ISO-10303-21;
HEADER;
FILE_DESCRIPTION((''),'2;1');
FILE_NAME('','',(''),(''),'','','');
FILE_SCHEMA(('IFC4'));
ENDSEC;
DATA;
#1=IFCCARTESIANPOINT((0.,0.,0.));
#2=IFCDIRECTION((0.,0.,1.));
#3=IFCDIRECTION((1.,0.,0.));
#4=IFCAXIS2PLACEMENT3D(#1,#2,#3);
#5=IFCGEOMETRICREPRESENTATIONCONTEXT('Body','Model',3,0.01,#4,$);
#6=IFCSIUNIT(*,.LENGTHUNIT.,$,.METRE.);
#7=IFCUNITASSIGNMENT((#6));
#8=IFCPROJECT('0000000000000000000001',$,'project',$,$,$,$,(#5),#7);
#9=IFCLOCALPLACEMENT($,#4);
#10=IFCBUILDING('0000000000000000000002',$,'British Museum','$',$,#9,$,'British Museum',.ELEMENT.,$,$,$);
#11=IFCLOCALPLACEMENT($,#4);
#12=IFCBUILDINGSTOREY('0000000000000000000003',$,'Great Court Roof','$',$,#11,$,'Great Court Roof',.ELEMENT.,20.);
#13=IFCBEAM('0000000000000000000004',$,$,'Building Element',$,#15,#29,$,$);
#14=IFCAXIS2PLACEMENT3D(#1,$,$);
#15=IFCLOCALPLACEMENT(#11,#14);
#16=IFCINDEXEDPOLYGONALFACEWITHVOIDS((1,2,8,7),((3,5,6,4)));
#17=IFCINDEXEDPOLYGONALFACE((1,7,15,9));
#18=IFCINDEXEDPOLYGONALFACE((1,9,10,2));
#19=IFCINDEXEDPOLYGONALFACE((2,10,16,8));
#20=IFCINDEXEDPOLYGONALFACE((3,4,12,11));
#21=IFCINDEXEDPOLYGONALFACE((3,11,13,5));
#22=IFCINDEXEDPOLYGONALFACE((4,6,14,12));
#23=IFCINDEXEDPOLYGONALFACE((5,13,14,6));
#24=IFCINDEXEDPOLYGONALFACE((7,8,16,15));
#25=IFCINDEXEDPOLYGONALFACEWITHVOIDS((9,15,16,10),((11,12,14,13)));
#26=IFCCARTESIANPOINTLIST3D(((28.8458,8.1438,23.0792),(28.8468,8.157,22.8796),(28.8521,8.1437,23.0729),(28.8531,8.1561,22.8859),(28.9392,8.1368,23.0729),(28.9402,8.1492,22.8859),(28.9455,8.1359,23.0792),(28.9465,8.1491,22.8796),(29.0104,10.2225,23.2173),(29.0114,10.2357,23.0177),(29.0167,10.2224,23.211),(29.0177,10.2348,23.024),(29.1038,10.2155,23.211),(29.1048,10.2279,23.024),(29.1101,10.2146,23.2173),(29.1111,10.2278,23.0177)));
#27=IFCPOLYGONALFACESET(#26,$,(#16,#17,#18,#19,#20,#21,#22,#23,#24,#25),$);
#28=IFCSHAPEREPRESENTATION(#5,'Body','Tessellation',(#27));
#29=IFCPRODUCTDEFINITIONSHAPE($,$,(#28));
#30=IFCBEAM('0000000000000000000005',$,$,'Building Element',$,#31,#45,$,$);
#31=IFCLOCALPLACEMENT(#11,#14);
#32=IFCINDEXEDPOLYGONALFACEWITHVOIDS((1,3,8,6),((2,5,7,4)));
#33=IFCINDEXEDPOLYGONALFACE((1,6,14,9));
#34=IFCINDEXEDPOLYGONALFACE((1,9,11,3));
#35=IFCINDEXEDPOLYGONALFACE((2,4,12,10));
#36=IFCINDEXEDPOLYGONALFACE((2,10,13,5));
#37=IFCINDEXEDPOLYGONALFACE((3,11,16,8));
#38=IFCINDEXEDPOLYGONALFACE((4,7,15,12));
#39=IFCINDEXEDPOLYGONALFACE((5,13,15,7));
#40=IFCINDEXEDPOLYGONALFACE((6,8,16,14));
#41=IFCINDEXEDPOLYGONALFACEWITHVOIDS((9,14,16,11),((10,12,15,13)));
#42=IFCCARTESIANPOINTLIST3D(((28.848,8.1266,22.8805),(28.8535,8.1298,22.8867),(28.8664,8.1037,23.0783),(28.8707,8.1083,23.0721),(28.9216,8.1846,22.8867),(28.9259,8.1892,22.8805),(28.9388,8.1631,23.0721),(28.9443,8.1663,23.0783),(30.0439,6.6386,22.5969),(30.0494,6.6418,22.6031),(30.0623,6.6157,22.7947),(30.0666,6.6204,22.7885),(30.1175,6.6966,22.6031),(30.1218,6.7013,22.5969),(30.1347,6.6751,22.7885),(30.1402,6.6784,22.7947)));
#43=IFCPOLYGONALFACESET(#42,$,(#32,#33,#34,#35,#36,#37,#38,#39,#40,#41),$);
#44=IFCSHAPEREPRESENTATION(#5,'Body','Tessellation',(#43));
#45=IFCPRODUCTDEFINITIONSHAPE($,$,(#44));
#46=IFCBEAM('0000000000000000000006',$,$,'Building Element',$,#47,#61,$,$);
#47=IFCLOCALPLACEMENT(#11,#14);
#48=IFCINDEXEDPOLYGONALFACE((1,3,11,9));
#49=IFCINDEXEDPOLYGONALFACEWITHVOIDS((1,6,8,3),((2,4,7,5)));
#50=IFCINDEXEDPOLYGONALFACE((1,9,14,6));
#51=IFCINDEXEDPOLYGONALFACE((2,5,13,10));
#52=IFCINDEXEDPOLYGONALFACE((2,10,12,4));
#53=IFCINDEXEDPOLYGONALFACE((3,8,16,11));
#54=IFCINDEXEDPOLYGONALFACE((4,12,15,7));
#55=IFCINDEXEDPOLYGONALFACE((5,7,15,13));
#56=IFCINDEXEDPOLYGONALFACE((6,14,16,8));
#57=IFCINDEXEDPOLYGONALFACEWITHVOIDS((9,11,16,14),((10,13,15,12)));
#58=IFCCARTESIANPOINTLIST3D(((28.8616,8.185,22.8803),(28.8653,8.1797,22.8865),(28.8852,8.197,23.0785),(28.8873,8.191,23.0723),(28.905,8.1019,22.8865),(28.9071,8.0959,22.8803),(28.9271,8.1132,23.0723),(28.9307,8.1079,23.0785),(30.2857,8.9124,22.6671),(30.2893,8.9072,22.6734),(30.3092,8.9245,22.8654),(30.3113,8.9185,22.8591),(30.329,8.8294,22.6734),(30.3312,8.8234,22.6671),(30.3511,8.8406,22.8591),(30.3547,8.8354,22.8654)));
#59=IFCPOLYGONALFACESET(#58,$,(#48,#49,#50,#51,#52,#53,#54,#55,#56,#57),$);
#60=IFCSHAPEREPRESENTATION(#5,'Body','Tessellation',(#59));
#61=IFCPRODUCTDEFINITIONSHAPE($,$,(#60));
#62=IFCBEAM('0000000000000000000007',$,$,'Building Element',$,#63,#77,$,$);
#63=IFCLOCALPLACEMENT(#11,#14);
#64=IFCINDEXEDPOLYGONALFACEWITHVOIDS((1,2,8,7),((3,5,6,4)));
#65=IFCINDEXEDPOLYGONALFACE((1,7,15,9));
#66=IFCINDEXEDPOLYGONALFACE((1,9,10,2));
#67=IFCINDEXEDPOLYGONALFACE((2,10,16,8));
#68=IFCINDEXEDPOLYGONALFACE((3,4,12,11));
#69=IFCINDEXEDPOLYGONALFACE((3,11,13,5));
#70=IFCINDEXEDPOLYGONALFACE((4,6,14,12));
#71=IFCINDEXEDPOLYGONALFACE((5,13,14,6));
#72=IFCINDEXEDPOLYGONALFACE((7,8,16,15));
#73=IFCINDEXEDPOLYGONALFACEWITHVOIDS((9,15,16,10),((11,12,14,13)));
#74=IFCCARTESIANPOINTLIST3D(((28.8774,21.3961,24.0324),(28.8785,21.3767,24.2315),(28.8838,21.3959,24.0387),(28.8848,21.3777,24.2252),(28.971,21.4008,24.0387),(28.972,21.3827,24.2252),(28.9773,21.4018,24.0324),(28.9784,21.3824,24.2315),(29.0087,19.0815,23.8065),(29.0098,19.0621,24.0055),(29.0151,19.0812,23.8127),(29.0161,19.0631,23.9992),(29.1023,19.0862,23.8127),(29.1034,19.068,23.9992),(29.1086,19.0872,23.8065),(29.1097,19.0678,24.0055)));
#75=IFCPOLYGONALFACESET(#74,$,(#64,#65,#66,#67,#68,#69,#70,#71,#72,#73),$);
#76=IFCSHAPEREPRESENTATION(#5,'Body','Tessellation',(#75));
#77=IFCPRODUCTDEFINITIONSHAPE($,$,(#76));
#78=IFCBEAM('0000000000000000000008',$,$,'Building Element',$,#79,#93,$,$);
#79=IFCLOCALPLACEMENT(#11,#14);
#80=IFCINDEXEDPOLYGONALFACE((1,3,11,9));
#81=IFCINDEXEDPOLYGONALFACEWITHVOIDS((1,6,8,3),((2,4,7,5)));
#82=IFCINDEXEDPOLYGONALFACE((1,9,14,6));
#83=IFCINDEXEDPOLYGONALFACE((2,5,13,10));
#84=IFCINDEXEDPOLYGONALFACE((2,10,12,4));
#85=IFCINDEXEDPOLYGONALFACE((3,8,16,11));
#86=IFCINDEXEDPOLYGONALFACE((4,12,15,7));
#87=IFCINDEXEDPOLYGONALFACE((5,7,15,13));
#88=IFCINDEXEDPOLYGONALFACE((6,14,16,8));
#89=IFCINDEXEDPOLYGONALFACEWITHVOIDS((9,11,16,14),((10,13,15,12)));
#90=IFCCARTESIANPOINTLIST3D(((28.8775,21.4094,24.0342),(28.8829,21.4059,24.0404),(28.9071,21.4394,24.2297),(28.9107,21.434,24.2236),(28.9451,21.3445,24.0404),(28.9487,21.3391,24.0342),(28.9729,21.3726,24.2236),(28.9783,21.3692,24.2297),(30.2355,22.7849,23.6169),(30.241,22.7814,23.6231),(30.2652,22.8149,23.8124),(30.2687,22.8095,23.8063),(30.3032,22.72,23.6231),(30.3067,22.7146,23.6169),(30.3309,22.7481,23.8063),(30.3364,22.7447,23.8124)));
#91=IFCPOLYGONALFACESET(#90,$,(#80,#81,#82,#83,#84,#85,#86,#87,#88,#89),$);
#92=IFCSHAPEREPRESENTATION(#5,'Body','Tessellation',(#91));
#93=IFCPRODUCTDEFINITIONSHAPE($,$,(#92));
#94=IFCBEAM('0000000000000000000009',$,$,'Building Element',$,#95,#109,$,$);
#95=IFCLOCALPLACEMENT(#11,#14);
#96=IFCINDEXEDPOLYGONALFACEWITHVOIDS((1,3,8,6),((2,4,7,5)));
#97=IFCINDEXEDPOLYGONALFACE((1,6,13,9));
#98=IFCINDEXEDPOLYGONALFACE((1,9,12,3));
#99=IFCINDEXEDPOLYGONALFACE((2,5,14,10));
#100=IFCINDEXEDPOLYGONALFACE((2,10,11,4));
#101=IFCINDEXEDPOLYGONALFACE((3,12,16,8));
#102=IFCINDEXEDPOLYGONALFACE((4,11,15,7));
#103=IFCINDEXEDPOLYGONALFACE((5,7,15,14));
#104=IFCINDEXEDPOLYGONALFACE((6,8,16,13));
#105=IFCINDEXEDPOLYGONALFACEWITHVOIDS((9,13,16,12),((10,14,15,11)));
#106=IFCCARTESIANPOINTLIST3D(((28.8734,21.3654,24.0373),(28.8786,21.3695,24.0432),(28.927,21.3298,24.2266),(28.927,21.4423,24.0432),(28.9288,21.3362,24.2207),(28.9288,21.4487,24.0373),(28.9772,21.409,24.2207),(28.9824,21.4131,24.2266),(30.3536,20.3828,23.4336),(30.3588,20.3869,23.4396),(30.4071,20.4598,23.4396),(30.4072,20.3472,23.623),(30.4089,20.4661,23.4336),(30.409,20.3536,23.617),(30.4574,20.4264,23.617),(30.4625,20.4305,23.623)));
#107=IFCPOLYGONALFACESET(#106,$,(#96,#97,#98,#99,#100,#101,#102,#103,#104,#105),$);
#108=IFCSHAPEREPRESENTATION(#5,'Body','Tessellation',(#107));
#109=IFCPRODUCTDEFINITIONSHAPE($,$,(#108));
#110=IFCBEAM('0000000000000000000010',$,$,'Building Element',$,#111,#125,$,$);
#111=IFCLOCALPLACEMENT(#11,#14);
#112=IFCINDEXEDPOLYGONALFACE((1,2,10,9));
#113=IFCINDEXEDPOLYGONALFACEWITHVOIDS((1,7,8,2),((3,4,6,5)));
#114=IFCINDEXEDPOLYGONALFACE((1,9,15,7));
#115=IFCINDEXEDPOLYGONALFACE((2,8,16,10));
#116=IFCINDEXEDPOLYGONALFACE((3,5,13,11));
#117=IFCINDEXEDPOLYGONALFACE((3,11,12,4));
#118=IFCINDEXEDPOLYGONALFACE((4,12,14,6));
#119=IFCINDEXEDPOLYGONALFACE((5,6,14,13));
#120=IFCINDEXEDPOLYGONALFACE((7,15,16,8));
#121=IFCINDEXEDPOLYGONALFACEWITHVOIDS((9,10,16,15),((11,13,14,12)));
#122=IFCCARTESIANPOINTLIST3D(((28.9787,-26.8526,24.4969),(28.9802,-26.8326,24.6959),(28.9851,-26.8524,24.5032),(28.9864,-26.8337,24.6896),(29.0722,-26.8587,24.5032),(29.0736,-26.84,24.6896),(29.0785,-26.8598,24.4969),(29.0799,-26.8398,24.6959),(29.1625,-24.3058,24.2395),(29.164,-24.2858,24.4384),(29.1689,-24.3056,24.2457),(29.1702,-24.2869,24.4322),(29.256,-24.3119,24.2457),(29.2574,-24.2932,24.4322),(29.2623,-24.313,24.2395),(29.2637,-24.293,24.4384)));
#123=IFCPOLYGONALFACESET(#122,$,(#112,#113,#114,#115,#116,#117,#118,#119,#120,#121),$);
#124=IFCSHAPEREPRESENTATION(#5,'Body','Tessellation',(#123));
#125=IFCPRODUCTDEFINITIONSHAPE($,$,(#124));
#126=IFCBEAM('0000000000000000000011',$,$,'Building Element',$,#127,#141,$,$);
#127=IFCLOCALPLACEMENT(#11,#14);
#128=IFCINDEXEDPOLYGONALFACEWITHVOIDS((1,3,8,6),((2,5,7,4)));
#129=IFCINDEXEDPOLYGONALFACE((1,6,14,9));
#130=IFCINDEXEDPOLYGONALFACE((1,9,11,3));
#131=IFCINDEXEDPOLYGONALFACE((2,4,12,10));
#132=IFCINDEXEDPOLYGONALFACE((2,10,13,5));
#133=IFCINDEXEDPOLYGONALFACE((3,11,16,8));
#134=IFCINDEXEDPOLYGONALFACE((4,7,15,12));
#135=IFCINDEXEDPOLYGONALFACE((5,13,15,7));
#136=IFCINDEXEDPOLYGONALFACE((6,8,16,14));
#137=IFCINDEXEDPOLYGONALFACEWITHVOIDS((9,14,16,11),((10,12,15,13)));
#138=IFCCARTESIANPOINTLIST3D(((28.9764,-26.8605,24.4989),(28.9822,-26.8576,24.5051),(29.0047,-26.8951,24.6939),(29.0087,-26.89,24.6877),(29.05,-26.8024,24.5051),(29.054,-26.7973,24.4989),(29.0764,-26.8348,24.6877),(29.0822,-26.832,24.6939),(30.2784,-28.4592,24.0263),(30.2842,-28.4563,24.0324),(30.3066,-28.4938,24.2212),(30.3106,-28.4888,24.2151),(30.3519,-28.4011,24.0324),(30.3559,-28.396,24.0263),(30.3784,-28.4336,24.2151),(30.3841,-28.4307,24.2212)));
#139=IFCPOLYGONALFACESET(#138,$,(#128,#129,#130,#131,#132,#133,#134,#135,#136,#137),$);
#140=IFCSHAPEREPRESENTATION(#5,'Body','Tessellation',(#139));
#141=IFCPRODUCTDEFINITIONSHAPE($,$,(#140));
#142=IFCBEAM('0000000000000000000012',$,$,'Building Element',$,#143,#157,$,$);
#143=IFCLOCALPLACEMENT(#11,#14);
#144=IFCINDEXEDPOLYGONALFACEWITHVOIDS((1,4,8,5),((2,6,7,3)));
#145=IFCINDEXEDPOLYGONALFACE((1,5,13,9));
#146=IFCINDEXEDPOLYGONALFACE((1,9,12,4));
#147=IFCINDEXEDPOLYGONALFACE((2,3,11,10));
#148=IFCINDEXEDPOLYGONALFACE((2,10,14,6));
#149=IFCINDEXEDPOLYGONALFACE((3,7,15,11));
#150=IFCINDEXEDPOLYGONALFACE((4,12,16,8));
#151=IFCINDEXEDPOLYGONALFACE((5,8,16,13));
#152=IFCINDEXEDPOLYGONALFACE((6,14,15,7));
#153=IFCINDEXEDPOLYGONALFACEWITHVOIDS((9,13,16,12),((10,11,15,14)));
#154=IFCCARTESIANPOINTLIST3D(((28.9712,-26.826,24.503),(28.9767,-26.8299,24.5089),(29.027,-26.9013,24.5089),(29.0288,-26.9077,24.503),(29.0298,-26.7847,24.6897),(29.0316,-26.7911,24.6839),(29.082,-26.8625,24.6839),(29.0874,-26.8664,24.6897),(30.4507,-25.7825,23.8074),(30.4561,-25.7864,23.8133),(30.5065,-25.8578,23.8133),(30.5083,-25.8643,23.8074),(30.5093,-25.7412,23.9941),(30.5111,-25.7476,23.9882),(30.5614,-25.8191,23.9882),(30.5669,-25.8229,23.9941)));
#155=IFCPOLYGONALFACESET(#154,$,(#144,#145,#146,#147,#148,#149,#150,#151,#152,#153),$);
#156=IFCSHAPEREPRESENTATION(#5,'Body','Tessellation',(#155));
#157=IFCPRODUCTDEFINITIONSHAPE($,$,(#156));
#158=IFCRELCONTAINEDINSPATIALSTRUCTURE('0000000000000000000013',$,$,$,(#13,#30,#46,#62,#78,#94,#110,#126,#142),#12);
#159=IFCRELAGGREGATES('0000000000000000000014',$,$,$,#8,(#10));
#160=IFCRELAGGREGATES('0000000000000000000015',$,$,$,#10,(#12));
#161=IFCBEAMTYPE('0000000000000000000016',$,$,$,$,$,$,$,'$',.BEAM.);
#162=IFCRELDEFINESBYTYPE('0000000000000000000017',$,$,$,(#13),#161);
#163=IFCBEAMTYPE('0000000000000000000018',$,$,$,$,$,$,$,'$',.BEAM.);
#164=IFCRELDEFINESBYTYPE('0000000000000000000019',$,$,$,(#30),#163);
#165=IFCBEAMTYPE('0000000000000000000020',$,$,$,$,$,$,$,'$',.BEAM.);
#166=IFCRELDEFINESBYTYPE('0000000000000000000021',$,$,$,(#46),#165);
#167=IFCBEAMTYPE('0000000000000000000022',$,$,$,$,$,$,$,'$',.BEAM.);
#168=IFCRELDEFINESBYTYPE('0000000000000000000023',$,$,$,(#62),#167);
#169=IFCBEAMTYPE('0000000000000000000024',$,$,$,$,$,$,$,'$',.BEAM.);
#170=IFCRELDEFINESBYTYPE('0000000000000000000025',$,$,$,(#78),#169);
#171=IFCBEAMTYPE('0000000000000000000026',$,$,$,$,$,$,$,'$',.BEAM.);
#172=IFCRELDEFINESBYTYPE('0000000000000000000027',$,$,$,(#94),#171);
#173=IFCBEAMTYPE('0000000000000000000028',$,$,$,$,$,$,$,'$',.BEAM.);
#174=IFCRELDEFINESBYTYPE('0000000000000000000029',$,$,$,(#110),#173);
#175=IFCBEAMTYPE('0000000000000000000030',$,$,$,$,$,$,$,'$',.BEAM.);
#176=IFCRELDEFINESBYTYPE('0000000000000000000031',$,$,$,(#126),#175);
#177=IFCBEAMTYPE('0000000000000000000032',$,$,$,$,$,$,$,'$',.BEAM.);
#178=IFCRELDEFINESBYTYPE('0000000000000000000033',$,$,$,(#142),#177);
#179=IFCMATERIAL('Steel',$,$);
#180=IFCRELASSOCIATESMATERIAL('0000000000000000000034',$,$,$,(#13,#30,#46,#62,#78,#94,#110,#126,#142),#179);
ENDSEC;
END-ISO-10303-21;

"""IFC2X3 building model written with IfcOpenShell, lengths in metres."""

from ifc_helpers import new_model, si_unit, frame, origin_with_axes, origin_2d, place, context, project, spatial, hollow_rectangle, extrude, material, type_object, element, save


model = new_model("IFC2X3")

# Units and contexts
model_context = context("Model", 3, precision=0.01, world=origin_with_axes(), identifier="Body")
ifc_project = project(units=[si_unit("LENGTHUNIT", "METRE")], contexts=[model_context])

# Building, storey
building_placement = place(None, origin_with_axes())
building = spatial("IfcBuilding", under=ifc_project, at=building_placement, Name="British Museum", Description="$", LongName="British Museum", CompositionType="ELEMENT")
storey_placement = place(None, origin_with_axes())
storey = spatial("IfcBuildingStorey", under=building, at=storey_placement, Name="Great Court Roof", Description="$", LongName="Great Court Roof", CompositionType="ELEMENT", Elevation=20.0)

# Beams
ifc_material = material(Name="Steel")
beam_type_1 = type_object("IfcBeamType", ElementType="$", PredefinedType="BEAM")
beam_1_placement = place(None, origin_with_axes())
element("IfcBeam", 1, at=beam_1_placement, inside=storey, type_object=beam_type_1, material=ifc_material, Description="Building Element", context=model_context, shape_type="SweptSolid", body=[
    extrude(hollow_rectangle(XDim=0.1, YDim=0.2, WallThickness=0.0063, InnerFilletRadius=-0.0063, OuterFilletRadius=0.0, at=origin_2d()), frame((28.8962, 8.1465, 22.9794), z_axis=(0.078759, 0.994701, 0.066078), x_axis=(-0.99688, 0.078932, 0.0)), (0.0, 0.0, 1.0), 2.0898),
])
beam_type_2 = type_object("IfcBeamType", ElementType="$", PredefinedType="BEAM")
beam_2_placement = place(None, origin_with_axes())
element("IfcBeam", 2, at=beam_2_placement, inside=storey, type_object=beam_type_2, material=ifc_material, Description="Building Element", context=model_context, shape_type="SweptSolid", body=[
    extrude(hollow_rectangle(XDim=0.1, YDim=0.2, WallThickness=0.0063, InnerFilletRadius=-0.0063, OuterFilletRadius=0.0, at=origin_2d()), frame((28.8962, 8.1465, 22.9794), z_axis=(0.619657, -0.770993, -0.146957), x_axis=(0.779455, 0.626458, 0.0)), (0.0, 0.0, 1.0), 1.9299),
])
beam_type_3 = type_object("IfcBeamType", ElementType="$", PredefinedType="BEAM")
beam_3_placement = place(None, origin_with_axes())
element("IfcBeam", 3, at=beam_3_placement, inside=storey, type_object=beam_type_3, material=ifc_material, Description="Building Element", context=model_context, shape_type="SweptSolid", body=[
    extrude(hollow_rectangle(XDim=0.1, YDim=0.2, WallThickness=0.0063, InnerFilletRadius=-0.0063, OuterFilletRadius=0.0, at=origin_2d()), frame((28.8962, 8.1465, 22.9794), z_axis=(0.88272, 0.450943, -0.132121), x_axis=(-0.454931, 0.890527, 0.0)), (0.0, 0.0, 1.0), 1.6132),
])
beam_type_4 = type_object("IfcBeamType", ElementType="$", PredefinedType="BEAM")
beam_4_placement = place(None, origin_with_axes())
element("IfcBeam", 4, at=beam_4_placement, inside=storey, type_object=beam_type_4, material=ifc_material, Description="Building Element", context=model_context, shape_type="SweptSolid", body=[
    extrude(hollow_rectangle(XDim=0.1, YDim=0.2, WallThickness=0.0063, InnerFilletRadius=-0.0063, OuterFilletRadius=0.0, at=origin_2d()), frame((28.9279, 21.3893, 24.132), z_axis=(0.056376, -0.993685, -0.097013), x_axis=(0.998395, 0.056643, 0.0)), (0.0, 0.0, 1.0), 2.3293),
])
beam_type_5 = type_object("IfcBeamType", ElementType="$", PredefinedType="BEAM")
beam_5_placement = place(None, origin_with_axes())
element("IfcBeam", 5, at=beam_5_placement, inside=storey, type_object=beam_type_5, material=ifc_material, Description="Building Element", context=model_context, shape_type="SweptSolid", body=[
    extrude(hollow_rectangle(XDim=0.1, YDim=0.2, WallThickness=0.0063, InnerFilletRadius=-0.0063, OuterFilletRadius=0.0, at=origin_2d()), frame((28.9279, 21.3893, 24.132), z_axis=(0.686755, 0.695585, -0.21102), x_axis=(-0.711609, 0.702575, 0.0)), (0.0, 0.0, 1.0), 1.9775),
])
beam_type_6 = type_object("IfcBeamType", ElementType="$", PredefinedType="BEAM")
beam_6_placement = place(None, origin_with_axes())
element("IfcBeam", 6, at=beam_6_placement, inside=storey, type_object=beam_type_6, material=ifc_material, Description="Building Element", context=model_context, shape_type="SweptSolid", body=[
    extrude(hollow_rectangle(XDim=0.1, YDim=0.2, WallThickness=0.0063, InnerFilletRadius=-0.0063, OuterFilletRadius=0.0, at=origin_2d()), frame((28.9279, 21.3893, 24.132), z_axis=(0.788851, -0.523661, -0.321704), x_axis=(0.553062, 0.83314, 0.0)), (0.0, 0.0, 1.0), 1.8764),
])
beam_type_7 = type_object("IfcBeamType", ElementType="$", PredefinedType="BEAM")
beam_7_placement = place(None, origin_with_axes())
element("IfcBeam", 7, at=beam_7_placement, inside=storey, type_object=beam_type_7, material=ifc_material, Description="Building Element", context=model_context, shape_type="SweptSolid", body=[
    extrude(hollow_rectangle(XDim=0.1, YDim=0.2, WallThickness=0.0063, InnerFilletRadius=-0.0063, OuterFilletRadius=0.0, at=origin_2d()), frame((29.0293, -26.8462, 24.5964), z_axis=(0.071622, 0.992375, -0.100314), x_axis=(-0.997406, 0.071985, 0.0)), (0.0, 0.0, 1.0), 2.5664),
])
beam_type_8 = type_object("IfcBeamType", ElementType="$", PredefinedType="BEAM")
beam_8_placement = place(None, origin_with_axes())
element("IfcBeam", 8, at=beam_8_placement, inside=storey, type_object=beam_type_8, material=ifc_material, Description="Building Element", context=model_context, shape_type="SweptSolid", body=[
    extrude(hollow_rectangle(XDim=0.1, YDim=0.2, WallThickness=0.0063, InnerFilletRadius=-0.0063, OuterFilletRadius=0.0, at=origin_2d()), frame((29.0293, -26.8462, 24.5964), z_axis=(0.615494, -0.755802, -0.223451), x_axis=(0.775408, 0.631461, 0.0)), (0.0, 0.0, 1.0), 2.1153),
])
beam_type_9 = type_object("IfcBeamType", ElementType="$", PredefinedType="BEAM")
beam_9_placement = place(None, origin_with_axes())
element("IfcBeam", 9, at=beam_9_placement, inside=storey, type_object=beam_type_9, material=ifc_material, Description="Building Element", context=model_context, shape_type="SweptSolid", body=[
    extrude(hollow_rectangle(XDim=0.1, YDim=0.2, WallThickness=0.0063, InnerFilletRadius=-0.0063, OuterFilletRadius=0.0, at=origin_2d()), frame((29.0293, -26.8462, 24.5964), z_axis=(0.762815, 0.538016, -0.358681), x_axis=(-0.576367, 0.817191, 0.0)), (0.0, 0.0, 1.0), 1.9395),
])

save(model, "model.ifc")
